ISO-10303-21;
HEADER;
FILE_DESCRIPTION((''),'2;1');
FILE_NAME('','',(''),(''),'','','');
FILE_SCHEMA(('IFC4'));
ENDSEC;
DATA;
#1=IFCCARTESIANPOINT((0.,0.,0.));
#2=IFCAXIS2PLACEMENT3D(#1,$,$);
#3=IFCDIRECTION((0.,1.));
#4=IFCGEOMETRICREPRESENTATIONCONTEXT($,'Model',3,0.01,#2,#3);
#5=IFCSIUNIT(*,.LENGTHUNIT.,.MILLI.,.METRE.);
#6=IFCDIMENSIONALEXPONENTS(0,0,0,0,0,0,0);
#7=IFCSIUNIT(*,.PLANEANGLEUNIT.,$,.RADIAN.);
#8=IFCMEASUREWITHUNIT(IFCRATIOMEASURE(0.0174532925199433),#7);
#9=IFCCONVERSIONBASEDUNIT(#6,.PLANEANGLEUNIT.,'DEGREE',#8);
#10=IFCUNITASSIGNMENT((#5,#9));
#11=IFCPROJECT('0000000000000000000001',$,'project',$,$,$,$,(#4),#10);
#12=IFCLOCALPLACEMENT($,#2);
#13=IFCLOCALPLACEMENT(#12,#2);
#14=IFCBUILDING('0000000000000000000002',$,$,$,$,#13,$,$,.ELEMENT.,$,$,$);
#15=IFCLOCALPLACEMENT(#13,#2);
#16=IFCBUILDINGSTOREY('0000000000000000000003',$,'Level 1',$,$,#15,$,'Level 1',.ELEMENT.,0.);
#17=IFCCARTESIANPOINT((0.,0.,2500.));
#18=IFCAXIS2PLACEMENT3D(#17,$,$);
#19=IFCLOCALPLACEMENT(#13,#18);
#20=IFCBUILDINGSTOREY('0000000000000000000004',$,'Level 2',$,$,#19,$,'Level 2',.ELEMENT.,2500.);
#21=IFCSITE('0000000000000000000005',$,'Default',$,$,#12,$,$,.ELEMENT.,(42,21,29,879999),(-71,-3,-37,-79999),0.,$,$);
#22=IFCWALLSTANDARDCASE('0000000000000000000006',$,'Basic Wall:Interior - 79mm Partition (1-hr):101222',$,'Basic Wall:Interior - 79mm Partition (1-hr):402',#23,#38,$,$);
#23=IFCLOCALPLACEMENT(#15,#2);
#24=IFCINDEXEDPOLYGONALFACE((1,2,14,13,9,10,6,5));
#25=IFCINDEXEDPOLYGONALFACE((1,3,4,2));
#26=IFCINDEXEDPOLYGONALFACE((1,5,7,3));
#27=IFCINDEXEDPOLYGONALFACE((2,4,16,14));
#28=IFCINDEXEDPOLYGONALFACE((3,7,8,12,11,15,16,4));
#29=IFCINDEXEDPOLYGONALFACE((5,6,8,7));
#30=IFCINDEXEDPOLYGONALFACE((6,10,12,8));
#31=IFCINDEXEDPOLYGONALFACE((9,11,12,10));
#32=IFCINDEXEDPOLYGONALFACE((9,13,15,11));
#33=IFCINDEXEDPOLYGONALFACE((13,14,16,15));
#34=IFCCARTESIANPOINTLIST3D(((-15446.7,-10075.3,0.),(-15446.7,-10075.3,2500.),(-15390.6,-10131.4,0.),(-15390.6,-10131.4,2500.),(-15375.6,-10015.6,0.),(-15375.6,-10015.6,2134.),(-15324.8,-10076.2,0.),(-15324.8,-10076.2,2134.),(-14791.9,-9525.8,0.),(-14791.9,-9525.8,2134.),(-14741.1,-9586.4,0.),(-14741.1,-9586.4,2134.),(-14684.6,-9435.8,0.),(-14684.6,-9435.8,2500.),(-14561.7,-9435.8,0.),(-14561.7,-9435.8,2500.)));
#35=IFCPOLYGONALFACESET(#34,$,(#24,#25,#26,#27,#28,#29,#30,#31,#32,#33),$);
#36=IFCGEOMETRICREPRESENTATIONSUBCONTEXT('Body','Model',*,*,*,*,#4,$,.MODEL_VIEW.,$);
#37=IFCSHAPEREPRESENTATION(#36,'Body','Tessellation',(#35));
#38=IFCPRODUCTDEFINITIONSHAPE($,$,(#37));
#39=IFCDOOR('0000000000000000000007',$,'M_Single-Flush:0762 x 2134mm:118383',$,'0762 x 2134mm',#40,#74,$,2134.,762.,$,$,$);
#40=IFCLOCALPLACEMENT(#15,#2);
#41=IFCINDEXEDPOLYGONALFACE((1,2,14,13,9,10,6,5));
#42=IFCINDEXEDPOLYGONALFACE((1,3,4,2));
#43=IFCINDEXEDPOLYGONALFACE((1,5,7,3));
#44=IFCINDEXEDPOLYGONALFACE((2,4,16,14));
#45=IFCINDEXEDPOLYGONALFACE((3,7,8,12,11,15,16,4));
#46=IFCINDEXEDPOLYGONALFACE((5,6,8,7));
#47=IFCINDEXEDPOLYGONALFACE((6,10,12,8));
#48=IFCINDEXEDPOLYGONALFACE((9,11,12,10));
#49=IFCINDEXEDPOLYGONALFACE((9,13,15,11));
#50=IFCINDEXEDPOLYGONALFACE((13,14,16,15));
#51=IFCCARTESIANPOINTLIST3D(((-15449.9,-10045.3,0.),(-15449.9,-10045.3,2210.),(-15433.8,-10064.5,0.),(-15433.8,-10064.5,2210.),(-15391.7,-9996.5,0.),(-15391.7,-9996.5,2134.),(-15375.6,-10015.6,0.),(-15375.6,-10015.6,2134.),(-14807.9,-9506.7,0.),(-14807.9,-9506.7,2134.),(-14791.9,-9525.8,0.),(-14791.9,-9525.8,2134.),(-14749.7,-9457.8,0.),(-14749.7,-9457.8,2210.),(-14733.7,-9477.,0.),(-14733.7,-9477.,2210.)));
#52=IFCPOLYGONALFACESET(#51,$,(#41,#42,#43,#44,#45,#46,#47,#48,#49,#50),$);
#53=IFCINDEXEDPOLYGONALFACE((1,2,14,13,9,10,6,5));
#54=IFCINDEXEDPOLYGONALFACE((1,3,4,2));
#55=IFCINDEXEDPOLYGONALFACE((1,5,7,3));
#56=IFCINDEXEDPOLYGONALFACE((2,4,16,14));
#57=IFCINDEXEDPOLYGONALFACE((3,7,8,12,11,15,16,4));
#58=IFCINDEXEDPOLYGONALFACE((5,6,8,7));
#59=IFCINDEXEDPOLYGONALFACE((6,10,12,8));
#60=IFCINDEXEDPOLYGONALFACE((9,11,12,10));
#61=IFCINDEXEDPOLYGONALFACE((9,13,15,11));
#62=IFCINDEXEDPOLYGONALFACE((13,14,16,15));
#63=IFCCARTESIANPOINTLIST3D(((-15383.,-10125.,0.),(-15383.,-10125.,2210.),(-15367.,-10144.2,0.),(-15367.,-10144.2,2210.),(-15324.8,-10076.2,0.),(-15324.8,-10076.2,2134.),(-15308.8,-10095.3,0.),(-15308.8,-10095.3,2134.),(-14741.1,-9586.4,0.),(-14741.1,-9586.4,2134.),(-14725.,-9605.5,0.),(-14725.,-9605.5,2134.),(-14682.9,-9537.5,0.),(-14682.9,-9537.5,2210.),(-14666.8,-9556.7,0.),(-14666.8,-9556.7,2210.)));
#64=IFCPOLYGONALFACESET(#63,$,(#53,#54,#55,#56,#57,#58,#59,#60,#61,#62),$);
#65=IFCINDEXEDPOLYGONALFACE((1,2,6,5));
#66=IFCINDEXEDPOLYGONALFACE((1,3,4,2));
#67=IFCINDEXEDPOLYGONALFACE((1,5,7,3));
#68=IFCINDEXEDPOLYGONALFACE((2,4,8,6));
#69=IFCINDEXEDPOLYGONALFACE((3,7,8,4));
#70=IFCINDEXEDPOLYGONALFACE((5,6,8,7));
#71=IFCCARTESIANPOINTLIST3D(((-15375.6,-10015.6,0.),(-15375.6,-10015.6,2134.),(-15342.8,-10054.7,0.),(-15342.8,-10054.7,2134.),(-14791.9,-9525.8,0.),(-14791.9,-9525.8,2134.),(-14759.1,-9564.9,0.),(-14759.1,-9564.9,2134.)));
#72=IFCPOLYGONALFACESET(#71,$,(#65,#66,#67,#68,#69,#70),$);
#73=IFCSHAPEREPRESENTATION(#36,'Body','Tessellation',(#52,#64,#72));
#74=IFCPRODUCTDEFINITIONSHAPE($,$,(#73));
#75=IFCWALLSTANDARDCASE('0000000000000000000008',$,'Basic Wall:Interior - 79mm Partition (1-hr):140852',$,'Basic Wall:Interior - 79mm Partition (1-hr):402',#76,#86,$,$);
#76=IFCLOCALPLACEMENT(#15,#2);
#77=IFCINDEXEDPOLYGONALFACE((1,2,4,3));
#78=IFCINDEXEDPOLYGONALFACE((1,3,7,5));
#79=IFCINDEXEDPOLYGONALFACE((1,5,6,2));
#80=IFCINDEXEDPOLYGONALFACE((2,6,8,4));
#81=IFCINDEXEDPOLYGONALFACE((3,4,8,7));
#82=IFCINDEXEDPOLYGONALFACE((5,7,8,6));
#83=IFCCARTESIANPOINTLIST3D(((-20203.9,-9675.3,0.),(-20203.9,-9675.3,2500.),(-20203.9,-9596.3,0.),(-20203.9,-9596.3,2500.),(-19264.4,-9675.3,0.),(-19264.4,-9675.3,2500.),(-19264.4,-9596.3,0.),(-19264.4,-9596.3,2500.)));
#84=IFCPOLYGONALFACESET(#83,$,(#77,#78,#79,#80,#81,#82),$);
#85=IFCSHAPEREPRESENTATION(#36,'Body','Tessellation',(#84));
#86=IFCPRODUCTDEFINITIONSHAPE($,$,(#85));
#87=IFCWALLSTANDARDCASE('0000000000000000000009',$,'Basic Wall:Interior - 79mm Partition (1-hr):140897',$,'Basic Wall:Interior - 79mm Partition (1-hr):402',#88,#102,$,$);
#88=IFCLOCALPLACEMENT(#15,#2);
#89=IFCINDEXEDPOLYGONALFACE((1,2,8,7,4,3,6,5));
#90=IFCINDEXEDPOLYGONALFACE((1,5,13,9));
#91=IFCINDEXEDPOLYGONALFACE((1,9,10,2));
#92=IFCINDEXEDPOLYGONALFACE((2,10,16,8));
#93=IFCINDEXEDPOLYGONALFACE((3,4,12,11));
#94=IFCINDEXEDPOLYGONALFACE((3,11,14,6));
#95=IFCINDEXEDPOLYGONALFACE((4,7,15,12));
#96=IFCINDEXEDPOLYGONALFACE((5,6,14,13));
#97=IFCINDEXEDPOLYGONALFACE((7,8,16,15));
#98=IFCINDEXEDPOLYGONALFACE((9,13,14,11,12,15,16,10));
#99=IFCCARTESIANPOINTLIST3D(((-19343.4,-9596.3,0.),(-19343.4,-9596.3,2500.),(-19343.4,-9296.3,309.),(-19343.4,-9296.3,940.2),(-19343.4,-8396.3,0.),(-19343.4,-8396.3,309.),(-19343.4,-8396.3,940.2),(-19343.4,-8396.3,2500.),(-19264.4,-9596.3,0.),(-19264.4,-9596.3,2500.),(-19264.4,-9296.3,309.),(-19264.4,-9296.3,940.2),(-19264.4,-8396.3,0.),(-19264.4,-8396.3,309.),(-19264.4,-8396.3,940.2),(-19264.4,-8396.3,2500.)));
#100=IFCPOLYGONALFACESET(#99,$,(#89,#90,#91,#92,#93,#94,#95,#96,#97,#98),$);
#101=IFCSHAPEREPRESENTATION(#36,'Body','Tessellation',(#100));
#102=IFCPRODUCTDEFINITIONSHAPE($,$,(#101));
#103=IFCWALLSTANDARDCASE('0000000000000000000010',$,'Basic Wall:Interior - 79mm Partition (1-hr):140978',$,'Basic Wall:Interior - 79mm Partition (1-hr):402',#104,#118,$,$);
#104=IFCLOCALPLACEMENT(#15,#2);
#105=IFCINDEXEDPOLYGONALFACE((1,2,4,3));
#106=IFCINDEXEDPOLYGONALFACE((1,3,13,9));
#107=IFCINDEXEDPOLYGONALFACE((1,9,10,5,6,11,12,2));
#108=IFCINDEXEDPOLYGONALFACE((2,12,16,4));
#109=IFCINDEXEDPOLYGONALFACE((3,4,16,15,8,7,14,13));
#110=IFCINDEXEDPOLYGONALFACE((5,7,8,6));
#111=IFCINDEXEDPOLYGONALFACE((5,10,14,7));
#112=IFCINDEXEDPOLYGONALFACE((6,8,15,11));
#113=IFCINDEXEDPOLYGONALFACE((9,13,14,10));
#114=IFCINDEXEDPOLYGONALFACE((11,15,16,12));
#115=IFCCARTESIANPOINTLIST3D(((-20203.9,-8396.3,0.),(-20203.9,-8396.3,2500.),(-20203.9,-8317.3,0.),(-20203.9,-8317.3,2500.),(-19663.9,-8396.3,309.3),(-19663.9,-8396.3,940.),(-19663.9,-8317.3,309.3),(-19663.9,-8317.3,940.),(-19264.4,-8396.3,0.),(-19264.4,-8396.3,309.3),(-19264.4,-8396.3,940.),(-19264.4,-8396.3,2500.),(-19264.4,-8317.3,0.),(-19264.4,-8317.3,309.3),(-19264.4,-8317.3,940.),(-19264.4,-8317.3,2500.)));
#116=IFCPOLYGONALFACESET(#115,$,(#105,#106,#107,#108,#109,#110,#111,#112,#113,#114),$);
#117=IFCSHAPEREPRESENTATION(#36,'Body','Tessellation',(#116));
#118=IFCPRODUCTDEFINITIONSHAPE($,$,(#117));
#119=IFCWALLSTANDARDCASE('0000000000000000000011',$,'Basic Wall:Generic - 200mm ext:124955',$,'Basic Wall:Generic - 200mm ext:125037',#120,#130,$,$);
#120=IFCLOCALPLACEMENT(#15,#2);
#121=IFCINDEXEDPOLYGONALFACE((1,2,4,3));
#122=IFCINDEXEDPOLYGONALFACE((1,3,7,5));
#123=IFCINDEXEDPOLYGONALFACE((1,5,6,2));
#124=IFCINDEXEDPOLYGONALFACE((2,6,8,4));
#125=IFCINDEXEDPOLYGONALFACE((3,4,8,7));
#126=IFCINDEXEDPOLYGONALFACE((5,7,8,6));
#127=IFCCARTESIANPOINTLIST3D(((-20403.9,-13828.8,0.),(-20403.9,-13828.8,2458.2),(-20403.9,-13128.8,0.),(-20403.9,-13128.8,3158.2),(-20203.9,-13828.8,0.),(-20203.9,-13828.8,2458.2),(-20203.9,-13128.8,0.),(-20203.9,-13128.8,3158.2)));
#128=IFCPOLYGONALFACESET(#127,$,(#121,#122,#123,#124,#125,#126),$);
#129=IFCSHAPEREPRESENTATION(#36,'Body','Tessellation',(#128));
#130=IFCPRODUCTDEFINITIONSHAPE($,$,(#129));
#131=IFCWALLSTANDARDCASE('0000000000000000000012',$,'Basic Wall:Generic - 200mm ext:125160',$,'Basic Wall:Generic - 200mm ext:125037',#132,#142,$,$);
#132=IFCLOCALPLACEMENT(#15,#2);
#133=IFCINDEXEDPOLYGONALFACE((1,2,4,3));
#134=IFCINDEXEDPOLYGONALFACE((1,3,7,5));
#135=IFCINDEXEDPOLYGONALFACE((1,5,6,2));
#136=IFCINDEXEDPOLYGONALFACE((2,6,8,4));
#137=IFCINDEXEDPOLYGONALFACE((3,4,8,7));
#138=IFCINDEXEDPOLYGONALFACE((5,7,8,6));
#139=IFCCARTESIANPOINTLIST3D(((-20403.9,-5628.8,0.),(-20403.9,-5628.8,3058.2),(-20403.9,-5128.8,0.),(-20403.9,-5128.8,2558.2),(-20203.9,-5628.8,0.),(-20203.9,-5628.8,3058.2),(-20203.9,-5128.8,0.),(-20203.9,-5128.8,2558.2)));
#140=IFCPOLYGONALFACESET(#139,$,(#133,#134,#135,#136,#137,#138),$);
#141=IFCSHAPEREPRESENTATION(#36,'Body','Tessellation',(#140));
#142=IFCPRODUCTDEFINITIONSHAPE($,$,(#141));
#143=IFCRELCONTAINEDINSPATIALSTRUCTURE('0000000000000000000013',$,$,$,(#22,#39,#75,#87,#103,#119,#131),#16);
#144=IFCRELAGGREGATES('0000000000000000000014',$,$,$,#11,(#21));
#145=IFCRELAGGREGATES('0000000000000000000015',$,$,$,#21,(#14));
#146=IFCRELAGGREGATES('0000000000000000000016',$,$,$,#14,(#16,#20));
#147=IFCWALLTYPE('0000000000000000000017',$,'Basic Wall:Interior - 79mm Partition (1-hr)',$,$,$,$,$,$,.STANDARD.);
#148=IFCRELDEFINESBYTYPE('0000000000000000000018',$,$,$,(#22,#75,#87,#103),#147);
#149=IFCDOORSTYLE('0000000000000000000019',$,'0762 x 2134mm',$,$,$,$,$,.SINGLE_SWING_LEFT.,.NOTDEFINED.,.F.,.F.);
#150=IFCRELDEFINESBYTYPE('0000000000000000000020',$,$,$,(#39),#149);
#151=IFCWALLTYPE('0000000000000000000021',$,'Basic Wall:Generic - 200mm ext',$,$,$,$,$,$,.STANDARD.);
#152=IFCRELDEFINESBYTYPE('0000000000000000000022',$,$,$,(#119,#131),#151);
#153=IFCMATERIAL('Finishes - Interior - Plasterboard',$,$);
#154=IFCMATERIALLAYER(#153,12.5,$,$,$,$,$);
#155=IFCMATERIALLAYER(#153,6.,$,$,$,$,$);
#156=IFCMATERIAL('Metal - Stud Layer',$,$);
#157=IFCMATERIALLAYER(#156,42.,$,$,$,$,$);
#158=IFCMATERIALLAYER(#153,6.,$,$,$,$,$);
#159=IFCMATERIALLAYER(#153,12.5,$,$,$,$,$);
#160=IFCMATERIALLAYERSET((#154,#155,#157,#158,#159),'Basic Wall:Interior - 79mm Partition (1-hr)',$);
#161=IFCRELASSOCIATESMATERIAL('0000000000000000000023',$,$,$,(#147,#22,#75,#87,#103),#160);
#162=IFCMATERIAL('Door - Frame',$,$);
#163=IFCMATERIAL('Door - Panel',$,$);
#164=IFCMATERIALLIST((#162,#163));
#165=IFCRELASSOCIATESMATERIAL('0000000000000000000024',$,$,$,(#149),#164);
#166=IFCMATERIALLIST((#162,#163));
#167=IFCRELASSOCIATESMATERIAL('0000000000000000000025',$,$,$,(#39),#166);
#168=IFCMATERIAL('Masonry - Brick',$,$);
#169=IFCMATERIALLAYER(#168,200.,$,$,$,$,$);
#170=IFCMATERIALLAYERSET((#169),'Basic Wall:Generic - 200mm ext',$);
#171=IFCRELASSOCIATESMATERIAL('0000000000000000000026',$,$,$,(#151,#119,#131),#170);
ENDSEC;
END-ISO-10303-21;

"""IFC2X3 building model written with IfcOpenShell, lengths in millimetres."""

from ifc_helpers import new_model, entity, si_unit, converted_unit, direction, frame, frame_2d, origin, origin_2d_with_axis, place, context, subcontext, project, spatial, polyline, rectangle, outline, extrude, clip, bounded_halfspace, source, transform, mapped, material, material_list, layer, layer_set, layer_usage, type_object, type_shapes, element, fill, save


model = new_model("IFC2X3")

# Units and contexts
model_context = context("Model", 3, precision=0.01, world=origin(), true_north=direction((0.0, 1.0)))
body_context = subcontext(model_context, "Body", "Model", "MODEL_VIEW")
ifc_project = project(units=[si_unit("LENGTHUNIT", "METRE", prefix="MILLI"), converted_unit("PLANEANGLEUNIT", "DEGREE", entity("IfcRatioMeasure", 0.0174532925199433), si_unit("PLANEANGLEUNIT", "RADIAN"), dimensions=[0, 0, 0, 0, 0, 0, 0])], contexts=[model_context])

# Site, building, storey
site_placement = place(None, origin())
site = spatial("IfcSite", under=ifc_project, at=site_placement, Name="Default", CompositionType="ELEMENT", RefLatitude=(42, 21, 29, 879999), RefLongitude=(-71, -3, -37, -79999), RefElevation=0.0)
building_placement = place(site_placement, origin())
building = spatial("IfcBuilding", under=site, at=building_placement, CompositionType="ELEMENT")
storey_1_placement = place(building_placement, origin())
storey_1 = spatial("IfcBuildingStorey", under=building, at=storey_1_placement, Name="Level 1", LongName="Level 1", CompositionType="ELEMENT", Elevation=0.0)

# Shared definitions
ifc_material_1 = material(Name="Masonry - Brick")

# Shared definitions
storey_2_placement = place(building_placement, frame((0.0, 0.0, 2500.0)))
storey_2 = spatial("IfcBuildingStorey", under=building, at=storey_2_placement, Name="Level 2", LongName="Level 2", CompositionType="ELEMENT", Elevation=2500.0)

# Shared definitions
ifc_material_2 = material(Name="Door - Frame")
ifc_material_3 = material(Name="Door - Panel")

# Shared definitions
ifc_material_4 = material(Name="Finishes - Interior - Plasterboard")
ifc_layer_1 = layer(ifc_material_4, 12.5)
ifc_layer_2 = layer(ifc_material_4, 6.0)
ifc_material_5 = material(Name="Metal - Stud Layer")
ifc_layer_3 = layer(ifc_material_5, 42.0)
ifc_layer_4 = layer(ifc_material_4, 6.0)
ifc_layer_5 = layer(ifc_material_4, 12.5)
ifc_layer_set_1 = layer_set([ifc_layer_1, ifc_layer_2, ifc_layer_3, ifc_layer_4, ifc_layer_5], Name="Basic Wall:Interior - 79mm Partition (1-hr)")
wall_type_1 = type_object("IfcWallType", Name="Basic Wall:Interior - 79mm Partition (1-hr)", PredefinedType="STANDARD", material=ifc_layer_set_1)

# Wall, opening, door
ifc_layer_usage_1 = layer_usage(ifc_layer_set_1, "AXIS2", "NEGATIVE", 39.5)
wall_1_placement = place(storey_1_placement, frame((-15421.3, -10105.5, 0.0), z_axis=(0.0, 0.0, 1.0), x_axis=(0.766044, 0.642788, 0.0)))
wall_1 = element("IfcWallStandardCase", 1, at=wall_1_placement, inside=storey_1, type_object=wall_type_1, material=ifc_layer_usage_1, Name="Basic Wall:Interior - 79mm Partition (1-hr):101222", ObjectType="Basic Wall:Interior - 79mm Partition (1-hr):402", context=body_context, shape_type="SweptSolid", body=[
    extrude(outline(polyline([(6.9, -39.5), (1089.0, -39.5), (994.8, 39.5), (0.0, 39.5), (6.9, -39.5)])), origin(), (0.0, 0.0, 1.0), 2500.0),
])
opening_1_placement = place(wall_1_placement, frame((92.8, -39.5, 0.0)))
opening_1 = element("IfcOpeningElement", 2, at=opening_1_placement, cuts=wall_1, ObjectType="Opening", context=body_context, shape_type="SweptSolid", body=[
    extrude(rectangle(XDim=762.0, YDim=2134.0, at=frame_2d((1067.0, 381.0), x_axis=(0.0, -1.0))), frame((0.0, 0.0, 0.0), z_axis=(0.0, 1.0, 0.0), x_axis=(0.0, 0.0, 1.0)), (0.0, 0.0, 1.0), 79.0),
])
ifc_material_list_1 = material_list([ifc_material_2, ifc_material_3])
ifc_material_list_2 = material_list([ifc_material_2, ifc_material_3])
door_style_1 = type_object("IfcDoorStyle", Name="0762 x 2134mm", ConstructionType="NOTDEFINED", OperationType="SINGLE_SWING_LEFT", ParameterTakesPrecedence=False, Sizeable=False, material=ifc_material_list_2)
shared_shape_1 = source(origin(), body_context, "Body", "SweptSolid", [
    extrude(outline(polyline([(-457.0, -1124.0), (457.0, -1124.0), (457.0, 1086.0), (381.0, 1086.0), (381.0, -1048.0), (-381.0, -1048.0), (-381.0, 1086.0), (-457.0, 1086.0), (-457.0, -1124.0)])), frame((381.0, 104.0, 1086.0), z_axis=(0.0, -1.0, 0.0), x_axis=(-1.0, 0.0, 0.0)), (0.0, 0.0, 1.0), 25.0),
    extrude(outline(polyline([(-1124.0, -457.0), (1086.0, -457.0), (1086.0, -381.0), (-1048.0, -381.0), (-1048.0, 381.0), (1086.0, 381.0), (1086.0, 457.0), (-1124.0, 457.0), (-1124.0, -457.0)])), frame((381.0, 0.0, 1086.0), z_axis=(0.0, -1.0, 0.0), x_axis=(0.0, 0.0, -1.0)), (0.0, 0.0, 1.0), 25.0),
    extrude(rectangle(XDim=762.0, YDim=51.0, at=origin_2d_with_axis()), frame((381.0, 53.5, 0.0)), (0.0, 0.0, 1.0), 2134.0),
])
type_shapes(door_style_1, [shared_shape_1])
door_1_placement = place(opening_1_placement, origin())
door_1 = element("IfcDoor", 3, at=door_1_placement, inside=storey_1, type_object=door_style_1, material=ifc_material_list_1, Name="M_Single-Flush:0762 x 2134mm:118383", ObjectType="0762 x 2134mm", OverallHeight=2134.0, OverallWidth=762.0, context=body_context, shape_type="MappedRepresentation", body=[
    mapped(shared_shape_1, transform((0.0, 0.0, 0.0), scale=1.0)),
])
fill(opening_1, door_1)

# Wall
ifc_layer_usage_2 = layer_usage(ifc_layer_set_1, "AXIS2", "NEGATIVE", 39.5)
wall_2_placement = place(storey_1_placement, frame((-20203.9, -9635.8, 0.0)))
element("IfcWallStandardCase", 4, at=wall_2_placement, inside=storey_1, type_object=wall_type_1, material=ifc_layer_usage_2, Name="Basic Wall:Interior - 79mm Partition (1-hr):140852", ObjectType="Basic Wall:Interior - 79mm Partition (1-hr):402", context=body_context, shape_type="SweptSolid", body=[
    extrude(rectangle(XDim=939.5, YDim=79.0, at=frame_2d((469.7, 0.0), x_axis=(-1.0, 0.0))), origin(), (0.0, 0.0, 1.0), 2500.0),
])

# Walls, openings
ifc_layer_usage_3 = layer_usage(ifc_layer_set_1, "AXIS2", "NEGATIVE", 39.5)
wall_3_placement = place(storey_1_placement, frame((-19303.9, -9596.3, 0.0), z_axis=(0.0, 0.0, 1.0), x_axis=(0.0, 1.0, 0.0)))
wall_3 = element("IfcWallStandardCase", 5, at=wall_3_placement, inside=storey_1, type_object=wall_type_1, material=ifc_layer_usage_3, Name="Basic Wall:Interior - 79mm Partition (1-hr):140897", ObjectType="Basic Wall:Interior - 79mm Partition (1-hr):402", context=body_context, shape_type="SweptSolid", body=[
    extrude(rectangle(XDim=1200.0, YDim=79.0, at=frame_2d((600.0, 0.0), x_axis=(-1.0, 0.0))), origin(), (0.0, 0.0, 1.0), 2500.0),
])
opening_2_placement = place(wall_3_placement, origin())
element("IfcOpeningElement", 6, at=opening_2_placement, cuts=wall_3, ObjectType="Opening", context=body_context, shape_type="SweptSolid", body=[
    extrude(rectangle(XDim=631.2, YDim=979.5, at=origin_2d_with_axis()), frame((789.8, -39.5, 624.6), z_axis=(0.0, 1.0, 0.0), x_axis=(0.0, 0.0, -1.0)), (0.0, 0.0, 1.0), 79.0),
])
ifc_layer_usage_4 = layer_usage(ifc_layer_set_1, "AXIS2", "NEGATIVE", 39.5)
wall_4_placement = place(storey_1_placement, frame((-19264.4, -8356.8, 0.0), z_axis=(0.0, 0.0, 1.0), x_axis=(-1.0, 0.0, 0.0)))
wall_4 = element("IfcWallStandardCase", 7, at=wall_4_placement, inside=storey_1, type_object=wall_type_1, material=ifc_layer_usage_4, Name="Basic Wall:Interior - 79mm Partition (1-hr):140978", ObjectType="Basic Wall:Interior - 79mm Partition (1-hr):402", context=body_context, shape_type="SweptSolid", body=[
    extrude(rectangle(XDim=939.5, YDim=79.0, at=frame_2d((469.7, 0.0), x_axis=(-1.0, 0.0))), origin(), (0.0, 0.0, 1.0), 2500.0),
])
opening_3_placement = place(wall_4_placement, origin())
element("IfcOpeningElement", 8, at=opening_3_placement, cuts=wall_4, ObjectType="Opening", context=body_context, shape_type="SweptSolid", body=[
    extrude(rectangle(XDim=630.7, YDim=399.9, at=frame_2d((0.0, 0.0), x_axis=(1.0, 0.0))), frame((199.6, -39.5, 624.6), z_axis=(0.0, 1.0, 0.0), x_axis=(0.0, 0.0, -1.0)), (0.0, 0.0, 1.0), 79.0),
])

# Walls
ifc_layer_6 = layer(ifc_material_1, 200.0)
ifc_layer_set_2 = layer_set([ifc_layer_6], Name="Basic Wall:Generic - 200mm ext")
ifc_layer_usage_5 = layer_usage(ifc_layer_set_2, "AXIS2", "NEGATIVE", 100.0)
wall_type_2 = type_object("IfcWallType", Name="Basic Wall:Generic - 200mm ext", PredefinedType="STANDARD", material=ifc_layer_set_2)
wall_5_placement = place(storey_1_placement, frame((-20303.9, -13128.8, 0.0), z_axis=(0.0, 0.0, 1.0), x_axis=(0.0, -1.0, 0.0)))
element("IfcWallStandardCase", 9, at=wall_5_placement, inside=storey_1, type_object=wall_type_2, material=ifc_layer_usage_5, Name="Basic Wall:Generic - 200mm ext:124955", ObjectType="Basic Wall:Generic - 200mm ext:125037", context=body_context, shape_type="Clipping", body=[
    clip(extrude(rectangle(XDim=700.0, YDim=200.0, at=frame_2d((350.0, 0.0), x_axis=(-1.0, 0.0))), origin(), (0.0, 0.0, 1.0), 3158.2), bounded_halfspace(frame((0.0, -100.0, 3158.2), z_axis=(-0.707107, 0.0, -0.707107), x_axis=(0.0, -1.0, 0.0)), True, frame((0.0, -100.0, 3158.2)), polyline([(0.0, 0.0), (700.0, 0.0), (700.0, 200.0), (0.0, 200.0), (0.0, 0.0)]))),
])
ifc_layer_usage_6 = layer_usage(ifc_layer_set_2, "AXIS2", "NEGATIVE", 100.0)
wall_6_placement = place(storey_1_placement, frame((-20303.9, -5628.8, 0.0), z_axis=(0.0, 0.0, 1.0), x_axis=(0.0, 1.0, 0.0)))
element("IfcWallStandardCase", 10, at=wall_6_placement, inside=storey_1, type_object=wall_type_2, material=ifc_layer_usage_6, Name="Basic Wall:Generic - 200mm ext:125160", ObjectType="Basic Wall:Generic - 200mm ext:125037", context=body_context, shape_type="Clipping", body=[
    clip(extrude(rectangle(XDim=500.0, YDim=200.0, at=frame_2d((250.0, 0.0), x_axis=(-1.0, 0.0))), origin(), (0.0, 0.0, 1.0), 3058.2), bounded_halfspace(frame((0.0, -100.0, 3058.2), z_axis=(-0.707107, 0.0, -0.707107), x_axis=(0.0, 1.0, 0.0)), True, frame((0.0, -100.0, 3058.2)), polyline([(0.0, 0.0), (500.0, 0.0), (500.0, 200.0), (0.0, 200.0), (0.0, 0.0)]))),
])

save(model, "model.ifc")
